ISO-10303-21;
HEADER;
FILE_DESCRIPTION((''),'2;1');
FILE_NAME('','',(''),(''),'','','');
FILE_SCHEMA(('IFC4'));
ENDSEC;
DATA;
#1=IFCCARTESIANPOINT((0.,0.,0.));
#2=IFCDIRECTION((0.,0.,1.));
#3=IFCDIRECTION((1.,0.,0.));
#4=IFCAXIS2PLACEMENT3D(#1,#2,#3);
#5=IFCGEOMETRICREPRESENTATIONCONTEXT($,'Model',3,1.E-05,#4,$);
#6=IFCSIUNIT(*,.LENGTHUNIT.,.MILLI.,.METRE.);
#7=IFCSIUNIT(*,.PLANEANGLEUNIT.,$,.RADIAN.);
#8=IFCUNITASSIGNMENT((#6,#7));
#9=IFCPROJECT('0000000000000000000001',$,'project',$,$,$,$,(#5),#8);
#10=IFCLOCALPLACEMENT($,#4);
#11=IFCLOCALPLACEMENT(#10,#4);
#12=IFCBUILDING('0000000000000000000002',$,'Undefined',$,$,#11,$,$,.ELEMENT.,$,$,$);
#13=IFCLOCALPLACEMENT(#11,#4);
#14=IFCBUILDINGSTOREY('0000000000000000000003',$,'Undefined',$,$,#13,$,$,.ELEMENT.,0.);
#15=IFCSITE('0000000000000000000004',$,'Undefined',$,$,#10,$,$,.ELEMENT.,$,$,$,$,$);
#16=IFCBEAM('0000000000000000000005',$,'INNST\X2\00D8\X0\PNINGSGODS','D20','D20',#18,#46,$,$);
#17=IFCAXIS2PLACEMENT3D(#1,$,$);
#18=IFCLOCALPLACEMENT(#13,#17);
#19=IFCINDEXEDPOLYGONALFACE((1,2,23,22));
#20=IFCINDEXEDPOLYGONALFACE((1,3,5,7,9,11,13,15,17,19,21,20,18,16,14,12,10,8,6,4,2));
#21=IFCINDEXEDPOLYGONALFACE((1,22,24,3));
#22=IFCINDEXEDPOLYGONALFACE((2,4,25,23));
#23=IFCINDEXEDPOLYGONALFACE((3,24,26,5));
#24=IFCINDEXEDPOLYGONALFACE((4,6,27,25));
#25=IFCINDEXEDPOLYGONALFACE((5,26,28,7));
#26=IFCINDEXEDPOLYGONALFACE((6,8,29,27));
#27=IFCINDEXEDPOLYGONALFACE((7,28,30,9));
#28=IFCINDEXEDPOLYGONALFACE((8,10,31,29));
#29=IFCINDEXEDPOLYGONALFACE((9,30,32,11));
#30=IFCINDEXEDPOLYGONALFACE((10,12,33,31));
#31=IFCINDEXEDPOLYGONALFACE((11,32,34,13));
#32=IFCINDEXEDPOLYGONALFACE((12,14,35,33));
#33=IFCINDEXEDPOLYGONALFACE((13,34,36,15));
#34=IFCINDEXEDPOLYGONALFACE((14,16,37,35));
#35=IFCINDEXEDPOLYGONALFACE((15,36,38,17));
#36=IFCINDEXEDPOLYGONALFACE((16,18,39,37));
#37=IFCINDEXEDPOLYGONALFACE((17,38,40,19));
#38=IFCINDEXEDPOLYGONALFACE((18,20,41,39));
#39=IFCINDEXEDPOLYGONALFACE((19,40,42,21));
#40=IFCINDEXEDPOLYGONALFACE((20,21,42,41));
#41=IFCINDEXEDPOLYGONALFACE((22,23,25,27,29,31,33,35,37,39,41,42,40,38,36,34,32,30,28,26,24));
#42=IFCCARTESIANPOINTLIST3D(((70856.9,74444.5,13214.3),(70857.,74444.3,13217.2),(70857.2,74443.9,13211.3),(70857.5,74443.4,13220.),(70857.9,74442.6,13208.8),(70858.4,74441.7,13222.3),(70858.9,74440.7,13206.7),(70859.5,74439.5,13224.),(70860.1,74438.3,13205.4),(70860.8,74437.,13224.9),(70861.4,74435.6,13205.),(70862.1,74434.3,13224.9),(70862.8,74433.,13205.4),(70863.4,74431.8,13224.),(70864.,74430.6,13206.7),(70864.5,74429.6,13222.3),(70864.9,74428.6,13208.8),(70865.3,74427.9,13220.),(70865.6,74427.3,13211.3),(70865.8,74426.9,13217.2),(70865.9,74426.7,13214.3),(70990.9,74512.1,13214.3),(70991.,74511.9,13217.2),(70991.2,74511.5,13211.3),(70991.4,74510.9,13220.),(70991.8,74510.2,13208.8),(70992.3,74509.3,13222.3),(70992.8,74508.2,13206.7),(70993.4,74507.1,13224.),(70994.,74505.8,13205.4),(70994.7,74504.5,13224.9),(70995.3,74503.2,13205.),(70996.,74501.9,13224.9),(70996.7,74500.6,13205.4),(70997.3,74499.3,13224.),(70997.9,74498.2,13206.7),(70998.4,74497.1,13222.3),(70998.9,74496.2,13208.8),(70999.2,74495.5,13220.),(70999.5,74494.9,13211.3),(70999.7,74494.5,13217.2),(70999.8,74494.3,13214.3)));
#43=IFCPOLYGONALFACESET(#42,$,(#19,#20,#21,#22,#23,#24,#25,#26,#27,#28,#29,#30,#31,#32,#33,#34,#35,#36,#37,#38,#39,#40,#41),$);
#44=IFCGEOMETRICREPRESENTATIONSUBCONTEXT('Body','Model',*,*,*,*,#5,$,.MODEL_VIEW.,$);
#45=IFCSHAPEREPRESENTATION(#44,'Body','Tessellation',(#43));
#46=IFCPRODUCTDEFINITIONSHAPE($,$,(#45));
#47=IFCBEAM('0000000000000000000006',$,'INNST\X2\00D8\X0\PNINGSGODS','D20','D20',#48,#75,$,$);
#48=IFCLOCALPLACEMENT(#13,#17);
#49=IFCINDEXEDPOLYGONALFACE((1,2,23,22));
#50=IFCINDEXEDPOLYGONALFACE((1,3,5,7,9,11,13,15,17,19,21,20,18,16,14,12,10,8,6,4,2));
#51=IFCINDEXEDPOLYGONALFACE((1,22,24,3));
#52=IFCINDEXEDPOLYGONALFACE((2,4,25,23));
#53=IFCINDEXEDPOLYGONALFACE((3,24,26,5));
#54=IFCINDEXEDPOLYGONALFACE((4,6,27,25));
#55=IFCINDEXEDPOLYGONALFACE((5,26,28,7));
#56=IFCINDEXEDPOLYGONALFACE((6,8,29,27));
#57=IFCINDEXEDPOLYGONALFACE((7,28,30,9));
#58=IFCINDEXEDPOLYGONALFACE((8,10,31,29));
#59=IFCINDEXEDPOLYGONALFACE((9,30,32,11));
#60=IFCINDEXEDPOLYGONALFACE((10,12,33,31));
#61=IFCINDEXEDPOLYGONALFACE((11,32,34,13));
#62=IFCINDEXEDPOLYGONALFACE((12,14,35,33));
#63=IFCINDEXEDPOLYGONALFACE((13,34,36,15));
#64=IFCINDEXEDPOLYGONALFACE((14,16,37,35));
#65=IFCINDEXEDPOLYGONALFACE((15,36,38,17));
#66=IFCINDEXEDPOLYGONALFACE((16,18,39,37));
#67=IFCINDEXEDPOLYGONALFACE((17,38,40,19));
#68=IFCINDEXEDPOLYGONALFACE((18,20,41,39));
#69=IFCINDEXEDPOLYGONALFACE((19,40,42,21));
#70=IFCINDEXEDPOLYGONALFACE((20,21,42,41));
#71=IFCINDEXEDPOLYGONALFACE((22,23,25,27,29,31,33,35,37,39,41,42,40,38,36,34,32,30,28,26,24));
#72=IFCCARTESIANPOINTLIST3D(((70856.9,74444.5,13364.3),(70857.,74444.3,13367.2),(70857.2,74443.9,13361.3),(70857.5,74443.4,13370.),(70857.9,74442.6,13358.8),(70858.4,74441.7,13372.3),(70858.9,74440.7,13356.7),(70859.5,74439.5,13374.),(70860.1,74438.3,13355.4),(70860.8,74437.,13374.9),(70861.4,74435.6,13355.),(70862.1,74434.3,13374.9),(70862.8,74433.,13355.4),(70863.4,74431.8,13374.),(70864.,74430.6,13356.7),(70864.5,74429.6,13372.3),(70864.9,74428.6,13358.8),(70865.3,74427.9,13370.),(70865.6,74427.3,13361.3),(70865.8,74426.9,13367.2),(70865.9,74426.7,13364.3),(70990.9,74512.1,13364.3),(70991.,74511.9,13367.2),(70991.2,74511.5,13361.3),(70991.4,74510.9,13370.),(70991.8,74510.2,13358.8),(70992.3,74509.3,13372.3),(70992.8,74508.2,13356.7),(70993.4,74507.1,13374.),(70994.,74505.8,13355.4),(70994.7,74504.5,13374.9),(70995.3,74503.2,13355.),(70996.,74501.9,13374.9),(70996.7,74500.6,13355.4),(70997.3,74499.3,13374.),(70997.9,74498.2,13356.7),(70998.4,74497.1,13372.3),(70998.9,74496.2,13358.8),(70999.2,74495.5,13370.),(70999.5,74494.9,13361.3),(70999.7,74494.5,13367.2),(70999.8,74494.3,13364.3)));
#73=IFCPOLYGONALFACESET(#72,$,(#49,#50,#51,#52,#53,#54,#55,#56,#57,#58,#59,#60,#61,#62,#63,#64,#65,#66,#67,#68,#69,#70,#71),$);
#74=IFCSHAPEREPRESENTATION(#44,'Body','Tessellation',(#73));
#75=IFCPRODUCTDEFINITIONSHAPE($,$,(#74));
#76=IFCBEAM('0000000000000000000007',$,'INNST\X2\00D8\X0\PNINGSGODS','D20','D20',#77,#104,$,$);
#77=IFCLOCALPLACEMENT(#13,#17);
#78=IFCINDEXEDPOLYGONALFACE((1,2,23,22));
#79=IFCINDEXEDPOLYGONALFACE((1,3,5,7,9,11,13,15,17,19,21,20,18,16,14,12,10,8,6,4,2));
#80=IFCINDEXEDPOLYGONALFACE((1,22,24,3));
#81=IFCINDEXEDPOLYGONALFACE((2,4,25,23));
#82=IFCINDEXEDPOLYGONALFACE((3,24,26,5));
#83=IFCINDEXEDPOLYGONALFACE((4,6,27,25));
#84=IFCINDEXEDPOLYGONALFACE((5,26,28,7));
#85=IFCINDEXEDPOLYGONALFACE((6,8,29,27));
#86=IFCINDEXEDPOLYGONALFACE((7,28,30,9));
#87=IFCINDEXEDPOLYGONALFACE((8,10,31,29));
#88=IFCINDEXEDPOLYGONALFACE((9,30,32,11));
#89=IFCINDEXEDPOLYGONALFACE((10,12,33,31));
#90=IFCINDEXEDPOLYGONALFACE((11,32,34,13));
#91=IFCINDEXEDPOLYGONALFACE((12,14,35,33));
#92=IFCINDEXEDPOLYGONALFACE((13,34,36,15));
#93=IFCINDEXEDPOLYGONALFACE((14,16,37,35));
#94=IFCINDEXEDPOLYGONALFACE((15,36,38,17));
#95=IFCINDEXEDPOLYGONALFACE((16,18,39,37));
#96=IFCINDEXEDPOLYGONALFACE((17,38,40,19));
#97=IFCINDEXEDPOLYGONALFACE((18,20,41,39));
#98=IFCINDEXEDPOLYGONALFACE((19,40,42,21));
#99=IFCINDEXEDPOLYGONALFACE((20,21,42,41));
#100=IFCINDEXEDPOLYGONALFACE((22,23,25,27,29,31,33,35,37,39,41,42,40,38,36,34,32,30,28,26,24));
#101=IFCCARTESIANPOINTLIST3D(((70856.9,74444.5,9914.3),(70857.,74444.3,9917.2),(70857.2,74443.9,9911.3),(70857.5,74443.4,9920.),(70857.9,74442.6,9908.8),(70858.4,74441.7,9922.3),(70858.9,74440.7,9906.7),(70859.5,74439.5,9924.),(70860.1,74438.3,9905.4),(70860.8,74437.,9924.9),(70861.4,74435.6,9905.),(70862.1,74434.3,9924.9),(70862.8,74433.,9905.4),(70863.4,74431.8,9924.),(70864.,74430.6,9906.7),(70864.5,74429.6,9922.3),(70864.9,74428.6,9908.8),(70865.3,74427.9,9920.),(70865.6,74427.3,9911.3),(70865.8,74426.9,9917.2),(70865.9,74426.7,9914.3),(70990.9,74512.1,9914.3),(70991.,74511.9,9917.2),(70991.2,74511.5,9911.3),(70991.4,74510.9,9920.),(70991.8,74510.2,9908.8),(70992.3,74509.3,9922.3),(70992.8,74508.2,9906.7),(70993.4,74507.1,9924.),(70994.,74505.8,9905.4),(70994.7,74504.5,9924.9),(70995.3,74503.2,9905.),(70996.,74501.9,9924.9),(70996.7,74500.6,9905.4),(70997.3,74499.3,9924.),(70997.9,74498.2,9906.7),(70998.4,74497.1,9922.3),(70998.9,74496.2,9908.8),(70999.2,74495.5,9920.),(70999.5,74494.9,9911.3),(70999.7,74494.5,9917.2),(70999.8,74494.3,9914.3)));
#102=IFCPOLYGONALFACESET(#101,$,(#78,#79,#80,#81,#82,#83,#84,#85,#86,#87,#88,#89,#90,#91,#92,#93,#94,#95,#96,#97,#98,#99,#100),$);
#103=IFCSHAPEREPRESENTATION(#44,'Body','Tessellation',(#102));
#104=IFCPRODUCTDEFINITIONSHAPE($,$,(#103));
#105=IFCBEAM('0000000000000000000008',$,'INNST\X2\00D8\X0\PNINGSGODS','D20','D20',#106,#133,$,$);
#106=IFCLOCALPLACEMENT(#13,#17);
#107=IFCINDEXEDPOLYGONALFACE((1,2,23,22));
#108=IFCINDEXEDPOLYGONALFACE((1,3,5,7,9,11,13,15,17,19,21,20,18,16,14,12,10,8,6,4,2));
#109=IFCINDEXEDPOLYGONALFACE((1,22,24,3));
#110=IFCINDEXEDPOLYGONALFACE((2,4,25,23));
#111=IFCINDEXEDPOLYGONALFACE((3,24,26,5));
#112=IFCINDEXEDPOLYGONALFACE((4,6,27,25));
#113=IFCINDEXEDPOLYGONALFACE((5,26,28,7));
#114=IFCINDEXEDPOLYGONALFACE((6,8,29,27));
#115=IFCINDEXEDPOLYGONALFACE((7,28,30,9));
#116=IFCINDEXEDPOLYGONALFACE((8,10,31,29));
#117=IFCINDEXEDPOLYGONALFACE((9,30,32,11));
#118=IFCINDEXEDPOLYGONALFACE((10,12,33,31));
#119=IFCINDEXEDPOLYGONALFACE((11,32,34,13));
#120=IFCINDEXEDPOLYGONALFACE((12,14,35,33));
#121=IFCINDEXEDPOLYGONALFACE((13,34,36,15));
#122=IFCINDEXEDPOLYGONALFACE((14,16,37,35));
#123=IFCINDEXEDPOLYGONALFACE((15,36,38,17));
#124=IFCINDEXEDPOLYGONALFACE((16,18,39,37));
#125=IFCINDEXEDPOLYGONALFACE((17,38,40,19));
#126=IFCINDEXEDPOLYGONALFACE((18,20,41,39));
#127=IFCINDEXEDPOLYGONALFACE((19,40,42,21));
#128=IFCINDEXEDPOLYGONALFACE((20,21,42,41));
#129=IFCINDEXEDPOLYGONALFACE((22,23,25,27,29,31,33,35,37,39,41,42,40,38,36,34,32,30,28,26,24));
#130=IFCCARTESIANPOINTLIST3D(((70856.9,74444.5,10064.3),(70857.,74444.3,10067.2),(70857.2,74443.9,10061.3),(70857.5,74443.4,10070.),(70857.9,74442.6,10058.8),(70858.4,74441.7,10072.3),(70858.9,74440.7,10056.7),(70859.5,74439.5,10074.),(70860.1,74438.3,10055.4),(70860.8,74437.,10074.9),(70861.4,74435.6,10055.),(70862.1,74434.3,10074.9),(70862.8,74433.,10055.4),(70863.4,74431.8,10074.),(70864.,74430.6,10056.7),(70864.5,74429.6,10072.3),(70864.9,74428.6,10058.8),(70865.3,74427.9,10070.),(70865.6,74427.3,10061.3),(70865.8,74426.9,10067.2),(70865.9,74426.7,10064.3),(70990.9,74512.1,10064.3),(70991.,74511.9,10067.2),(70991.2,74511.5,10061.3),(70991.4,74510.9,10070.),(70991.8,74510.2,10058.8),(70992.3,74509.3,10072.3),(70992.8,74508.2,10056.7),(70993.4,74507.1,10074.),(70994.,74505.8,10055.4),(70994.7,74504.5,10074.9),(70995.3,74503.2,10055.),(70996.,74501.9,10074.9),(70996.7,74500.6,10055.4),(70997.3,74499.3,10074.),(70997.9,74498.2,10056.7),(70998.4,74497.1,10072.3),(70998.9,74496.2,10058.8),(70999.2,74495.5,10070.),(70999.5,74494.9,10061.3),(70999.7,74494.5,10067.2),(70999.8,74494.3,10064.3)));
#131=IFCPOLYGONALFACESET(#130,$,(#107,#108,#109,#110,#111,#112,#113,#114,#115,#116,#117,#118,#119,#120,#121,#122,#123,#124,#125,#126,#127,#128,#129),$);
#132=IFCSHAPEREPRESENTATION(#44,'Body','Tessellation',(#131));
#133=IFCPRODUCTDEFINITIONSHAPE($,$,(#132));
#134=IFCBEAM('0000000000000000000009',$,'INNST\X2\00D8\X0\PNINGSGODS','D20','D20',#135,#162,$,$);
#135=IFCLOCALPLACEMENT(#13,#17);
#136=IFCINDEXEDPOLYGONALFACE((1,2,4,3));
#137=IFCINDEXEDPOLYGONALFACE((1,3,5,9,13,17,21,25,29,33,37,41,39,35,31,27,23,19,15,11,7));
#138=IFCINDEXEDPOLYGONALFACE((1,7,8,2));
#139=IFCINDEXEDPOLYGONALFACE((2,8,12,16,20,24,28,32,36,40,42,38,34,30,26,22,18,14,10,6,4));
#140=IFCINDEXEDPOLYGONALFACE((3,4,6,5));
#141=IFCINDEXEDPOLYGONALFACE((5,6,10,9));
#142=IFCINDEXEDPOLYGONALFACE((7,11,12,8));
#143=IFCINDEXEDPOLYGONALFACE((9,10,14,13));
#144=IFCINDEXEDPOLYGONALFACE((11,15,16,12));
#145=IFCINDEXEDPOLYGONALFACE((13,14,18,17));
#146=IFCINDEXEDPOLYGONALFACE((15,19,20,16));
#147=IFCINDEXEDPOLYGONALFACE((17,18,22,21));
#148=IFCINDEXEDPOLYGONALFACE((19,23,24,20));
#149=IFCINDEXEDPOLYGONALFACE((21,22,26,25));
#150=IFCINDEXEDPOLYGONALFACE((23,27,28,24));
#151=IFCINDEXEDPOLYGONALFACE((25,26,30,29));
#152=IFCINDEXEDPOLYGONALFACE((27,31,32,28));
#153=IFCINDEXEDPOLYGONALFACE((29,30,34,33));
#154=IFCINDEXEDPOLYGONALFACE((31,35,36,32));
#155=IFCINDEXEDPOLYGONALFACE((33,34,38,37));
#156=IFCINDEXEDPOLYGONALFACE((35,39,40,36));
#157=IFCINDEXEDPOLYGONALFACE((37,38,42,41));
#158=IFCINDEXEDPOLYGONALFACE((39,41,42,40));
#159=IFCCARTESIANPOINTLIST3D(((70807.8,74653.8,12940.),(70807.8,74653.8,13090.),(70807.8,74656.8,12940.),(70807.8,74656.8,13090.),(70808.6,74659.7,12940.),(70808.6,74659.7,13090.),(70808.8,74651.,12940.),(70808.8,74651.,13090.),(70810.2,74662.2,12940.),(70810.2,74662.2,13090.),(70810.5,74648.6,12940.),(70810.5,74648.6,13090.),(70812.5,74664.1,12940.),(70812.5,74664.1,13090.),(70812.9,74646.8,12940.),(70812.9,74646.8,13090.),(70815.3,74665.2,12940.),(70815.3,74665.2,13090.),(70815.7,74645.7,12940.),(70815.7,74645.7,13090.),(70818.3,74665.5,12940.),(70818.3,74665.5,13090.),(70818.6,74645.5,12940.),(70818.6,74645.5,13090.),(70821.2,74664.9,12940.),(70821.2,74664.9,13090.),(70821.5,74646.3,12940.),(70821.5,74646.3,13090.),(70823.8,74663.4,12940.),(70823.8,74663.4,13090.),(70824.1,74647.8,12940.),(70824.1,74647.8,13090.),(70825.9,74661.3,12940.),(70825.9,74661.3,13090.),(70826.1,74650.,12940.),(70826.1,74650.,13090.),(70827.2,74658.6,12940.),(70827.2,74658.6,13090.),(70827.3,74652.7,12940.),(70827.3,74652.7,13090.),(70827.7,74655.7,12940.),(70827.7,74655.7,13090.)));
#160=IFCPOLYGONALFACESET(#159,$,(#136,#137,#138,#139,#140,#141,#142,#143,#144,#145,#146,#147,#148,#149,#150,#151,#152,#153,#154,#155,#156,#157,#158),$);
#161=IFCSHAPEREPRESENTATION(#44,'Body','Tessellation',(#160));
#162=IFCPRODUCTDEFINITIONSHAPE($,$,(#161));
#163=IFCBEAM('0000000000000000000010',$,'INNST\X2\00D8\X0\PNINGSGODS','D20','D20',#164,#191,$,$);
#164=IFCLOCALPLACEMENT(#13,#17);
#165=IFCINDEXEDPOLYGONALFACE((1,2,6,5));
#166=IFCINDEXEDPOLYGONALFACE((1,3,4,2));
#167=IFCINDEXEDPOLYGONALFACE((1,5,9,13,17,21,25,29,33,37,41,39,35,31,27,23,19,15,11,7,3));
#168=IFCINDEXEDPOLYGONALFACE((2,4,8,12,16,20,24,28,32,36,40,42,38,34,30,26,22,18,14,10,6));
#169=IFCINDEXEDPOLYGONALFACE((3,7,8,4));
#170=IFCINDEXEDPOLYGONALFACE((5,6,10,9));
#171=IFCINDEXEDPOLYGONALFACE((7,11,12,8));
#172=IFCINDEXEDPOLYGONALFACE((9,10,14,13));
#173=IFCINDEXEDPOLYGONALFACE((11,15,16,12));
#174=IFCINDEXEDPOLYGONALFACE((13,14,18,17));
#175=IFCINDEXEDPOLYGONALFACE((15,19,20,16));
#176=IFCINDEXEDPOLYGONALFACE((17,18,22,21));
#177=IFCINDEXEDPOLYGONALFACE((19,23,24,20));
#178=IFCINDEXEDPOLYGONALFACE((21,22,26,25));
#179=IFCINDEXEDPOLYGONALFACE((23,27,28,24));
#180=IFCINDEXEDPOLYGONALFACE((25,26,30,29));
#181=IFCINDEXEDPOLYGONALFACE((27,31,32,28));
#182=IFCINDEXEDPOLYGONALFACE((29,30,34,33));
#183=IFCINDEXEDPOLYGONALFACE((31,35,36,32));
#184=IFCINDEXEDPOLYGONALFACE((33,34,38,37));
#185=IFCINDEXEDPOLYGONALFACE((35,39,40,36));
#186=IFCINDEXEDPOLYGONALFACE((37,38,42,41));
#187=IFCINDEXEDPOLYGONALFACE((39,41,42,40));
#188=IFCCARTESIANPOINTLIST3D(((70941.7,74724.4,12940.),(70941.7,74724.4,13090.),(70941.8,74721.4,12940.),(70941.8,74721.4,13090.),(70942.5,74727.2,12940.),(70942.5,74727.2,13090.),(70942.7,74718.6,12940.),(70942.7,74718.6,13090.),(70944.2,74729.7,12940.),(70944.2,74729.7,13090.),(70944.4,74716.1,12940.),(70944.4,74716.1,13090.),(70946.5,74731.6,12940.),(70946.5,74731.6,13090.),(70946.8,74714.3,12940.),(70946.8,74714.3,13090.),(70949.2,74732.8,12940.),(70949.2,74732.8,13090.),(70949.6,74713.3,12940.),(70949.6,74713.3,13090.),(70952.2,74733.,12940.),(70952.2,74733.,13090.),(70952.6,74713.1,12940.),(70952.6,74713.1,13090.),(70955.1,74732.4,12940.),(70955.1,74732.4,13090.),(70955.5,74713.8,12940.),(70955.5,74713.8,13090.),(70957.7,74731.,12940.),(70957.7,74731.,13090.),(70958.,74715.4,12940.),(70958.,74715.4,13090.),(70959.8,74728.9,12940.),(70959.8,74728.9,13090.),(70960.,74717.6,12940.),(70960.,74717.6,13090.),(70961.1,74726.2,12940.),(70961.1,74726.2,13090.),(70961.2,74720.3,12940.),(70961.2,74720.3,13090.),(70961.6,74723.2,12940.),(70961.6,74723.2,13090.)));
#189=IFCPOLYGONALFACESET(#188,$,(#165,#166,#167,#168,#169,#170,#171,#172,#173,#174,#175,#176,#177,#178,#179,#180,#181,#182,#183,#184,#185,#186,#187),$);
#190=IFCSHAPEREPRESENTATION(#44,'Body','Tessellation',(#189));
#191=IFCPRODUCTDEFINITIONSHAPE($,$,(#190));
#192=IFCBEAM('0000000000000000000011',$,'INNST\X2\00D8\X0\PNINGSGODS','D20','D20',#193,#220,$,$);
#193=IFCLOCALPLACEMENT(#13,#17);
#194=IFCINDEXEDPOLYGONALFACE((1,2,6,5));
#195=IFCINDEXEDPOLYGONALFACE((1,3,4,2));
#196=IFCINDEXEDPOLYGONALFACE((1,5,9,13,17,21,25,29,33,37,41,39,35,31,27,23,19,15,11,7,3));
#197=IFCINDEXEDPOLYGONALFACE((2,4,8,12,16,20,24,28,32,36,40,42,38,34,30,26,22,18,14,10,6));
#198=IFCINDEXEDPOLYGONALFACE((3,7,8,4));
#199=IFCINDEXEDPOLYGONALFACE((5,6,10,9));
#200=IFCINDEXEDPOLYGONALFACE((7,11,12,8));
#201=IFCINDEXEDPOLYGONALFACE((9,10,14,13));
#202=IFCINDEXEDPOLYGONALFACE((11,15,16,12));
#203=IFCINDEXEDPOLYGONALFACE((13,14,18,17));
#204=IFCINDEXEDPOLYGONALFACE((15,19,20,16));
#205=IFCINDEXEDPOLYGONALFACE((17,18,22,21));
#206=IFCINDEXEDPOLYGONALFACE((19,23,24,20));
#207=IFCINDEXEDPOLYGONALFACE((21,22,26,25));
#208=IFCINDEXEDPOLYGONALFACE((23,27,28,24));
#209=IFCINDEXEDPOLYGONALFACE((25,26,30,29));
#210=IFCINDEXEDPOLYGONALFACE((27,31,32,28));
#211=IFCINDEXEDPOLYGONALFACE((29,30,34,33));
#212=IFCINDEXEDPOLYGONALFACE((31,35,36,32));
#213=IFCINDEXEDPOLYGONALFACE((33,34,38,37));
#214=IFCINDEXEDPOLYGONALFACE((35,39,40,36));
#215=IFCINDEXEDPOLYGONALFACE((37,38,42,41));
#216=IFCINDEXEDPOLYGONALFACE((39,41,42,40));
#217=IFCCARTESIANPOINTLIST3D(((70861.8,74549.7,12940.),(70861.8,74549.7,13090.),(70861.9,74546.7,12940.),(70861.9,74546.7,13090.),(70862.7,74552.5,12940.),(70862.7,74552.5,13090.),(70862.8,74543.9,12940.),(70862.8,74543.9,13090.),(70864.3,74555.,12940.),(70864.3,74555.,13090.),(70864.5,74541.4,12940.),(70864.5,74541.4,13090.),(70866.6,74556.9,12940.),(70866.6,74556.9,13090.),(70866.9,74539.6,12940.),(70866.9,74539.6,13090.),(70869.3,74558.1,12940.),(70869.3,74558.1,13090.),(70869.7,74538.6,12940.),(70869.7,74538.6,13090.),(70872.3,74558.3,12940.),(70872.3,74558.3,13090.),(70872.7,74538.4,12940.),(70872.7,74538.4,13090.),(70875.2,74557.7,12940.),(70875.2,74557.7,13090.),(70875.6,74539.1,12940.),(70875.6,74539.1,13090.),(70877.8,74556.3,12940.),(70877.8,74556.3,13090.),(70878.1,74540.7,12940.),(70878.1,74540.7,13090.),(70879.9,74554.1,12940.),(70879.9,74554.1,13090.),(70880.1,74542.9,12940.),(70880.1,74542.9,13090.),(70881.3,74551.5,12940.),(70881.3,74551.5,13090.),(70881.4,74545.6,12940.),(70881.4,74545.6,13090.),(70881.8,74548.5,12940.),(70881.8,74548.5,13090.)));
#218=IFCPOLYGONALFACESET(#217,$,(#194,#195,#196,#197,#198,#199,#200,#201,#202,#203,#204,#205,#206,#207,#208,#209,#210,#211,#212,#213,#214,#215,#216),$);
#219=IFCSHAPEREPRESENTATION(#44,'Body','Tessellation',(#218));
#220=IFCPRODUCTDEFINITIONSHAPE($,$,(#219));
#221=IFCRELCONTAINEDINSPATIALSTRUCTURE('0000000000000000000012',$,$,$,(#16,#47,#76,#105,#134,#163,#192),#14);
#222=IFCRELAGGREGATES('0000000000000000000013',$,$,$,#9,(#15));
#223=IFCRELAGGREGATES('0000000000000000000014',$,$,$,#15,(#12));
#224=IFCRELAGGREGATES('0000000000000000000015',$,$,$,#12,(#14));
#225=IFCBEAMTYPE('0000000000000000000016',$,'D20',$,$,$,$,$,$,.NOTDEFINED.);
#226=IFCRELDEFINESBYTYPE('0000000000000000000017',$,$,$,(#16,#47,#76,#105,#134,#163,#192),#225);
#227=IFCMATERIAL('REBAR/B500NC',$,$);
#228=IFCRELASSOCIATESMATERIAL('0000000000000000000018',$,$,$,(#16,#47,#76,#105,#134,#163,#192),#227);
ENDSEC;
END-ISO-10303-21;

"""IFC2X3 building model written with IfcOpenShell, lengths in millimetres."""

from ifc_helpers import new_model, si_unit, frame, origin_with_axes, origin_2d_with_axis, place, context, subcontext, project, spatial, circle, extrude, material, type_object, element, save


model = new_model("IFC2X3")

# Units and contexts
model_context = context("Model", 3, precision=1e-05, world=origin_with_axes())
body_context = subcontext(model_context, "Body", "Model", "MODEL_VIEW")
ifc_project = project(units=[si_unit("LENGTHUNIT", "METRE", prefix="MILLI"), si_unit("PLANEANGLEUNIT", "RADIAN")], contexts=[model_context])

# Site, building, storey
site_placement = place(None, origin_with_axes())
site = spatial("IfcSite", under=ifc_project, at=site_placement, Name="Undefined", CompositionType="ELEMENT")
building_placement = place(site_placement, origin_with_axes())
building = spatial("IfcBuilding", under=site, at=building_placement, Name="Undefined", CompositionType="ELEMENT")
storey_placement = place(building_placement, origin_with_axes())
storey = spatial("IfcBuildingStorey", under=building, at=storey_placement, Name="Undefined", CompositionType="ELEMENT", Elevation=0.0)

# Beams
ifc_material_1 = material(Name="REBAR/B500NC")
beam_type_1 = type_object("IfcBeamType", Name="D20", PredefinedType="NOTDEFINED")
for number, where, z_axis, x_axis, name in (
    (1, (70995.3, 74503.2, 13215.0), (-0.45041, 0.892822, 0.0), (-0.892821, -0.450411, 0.0), "INNSTØPNINGSGODS"),
    (2, (70995.3, 74503.2, 13365.0), (-0.45041, 0.892822, 0.0), (-0.892821, -0.450411, 0.0), "INNSTØPNINGSGODS"),
    (3, (70995.3, 74503.2, 9915.0), (-0.45041, 0.892822, 0.0), (-0.892821, -0.450411, 0.0), "INNSTØPNINGSGODS"),
    (4, (70995.3, 74503.2, 10065.0), (-0.45041, 0.892822, 0.0), (-0.892821, -0.450411, 0.0), "INNSTØPNINGSGODS"),
    (5, (70817.7, 74655.5, 13090.0), (0.450411, -0.892821, 0.0), (0.0, 0.0, -1.0), "INNSTØPNINGSGODS"),
    (6, (70951.6, 74723.1, 13090.0), (0.450411, -0.892821, 0.0), (0.0, 0.0, -1.0), "INNSTØPNINGSGODS"),
    (7, (70871.8, 74548.4, 13090.0), (0.450411, -0.892821, 0.0), (0.0, 0.0, -1.0), "INNSTØPNINGSGODS"),
):
    element("IfcBeam", number, at=place(storey_placement, frame(where, z_axis=z_axis, x_axis=x_axis)), inside=storey, type_object=beam_type_1, material=ifc_material_1, Name=name, Description="D20", ObjectType="D20", context=body_context, shape_type="SweptSolid", body=[
        extrude(circle(Radius=10.0, at=origin_2d_with_axis()), frame((150.0, 0.0, 0.0), z_axis=(-1.0, 0.0, 0.0), x_axis=(0.0, -1.0, 0.0)), (0.0, 0.0, 1.0), 150.0),
    ])

save(model, "model.ifc")
